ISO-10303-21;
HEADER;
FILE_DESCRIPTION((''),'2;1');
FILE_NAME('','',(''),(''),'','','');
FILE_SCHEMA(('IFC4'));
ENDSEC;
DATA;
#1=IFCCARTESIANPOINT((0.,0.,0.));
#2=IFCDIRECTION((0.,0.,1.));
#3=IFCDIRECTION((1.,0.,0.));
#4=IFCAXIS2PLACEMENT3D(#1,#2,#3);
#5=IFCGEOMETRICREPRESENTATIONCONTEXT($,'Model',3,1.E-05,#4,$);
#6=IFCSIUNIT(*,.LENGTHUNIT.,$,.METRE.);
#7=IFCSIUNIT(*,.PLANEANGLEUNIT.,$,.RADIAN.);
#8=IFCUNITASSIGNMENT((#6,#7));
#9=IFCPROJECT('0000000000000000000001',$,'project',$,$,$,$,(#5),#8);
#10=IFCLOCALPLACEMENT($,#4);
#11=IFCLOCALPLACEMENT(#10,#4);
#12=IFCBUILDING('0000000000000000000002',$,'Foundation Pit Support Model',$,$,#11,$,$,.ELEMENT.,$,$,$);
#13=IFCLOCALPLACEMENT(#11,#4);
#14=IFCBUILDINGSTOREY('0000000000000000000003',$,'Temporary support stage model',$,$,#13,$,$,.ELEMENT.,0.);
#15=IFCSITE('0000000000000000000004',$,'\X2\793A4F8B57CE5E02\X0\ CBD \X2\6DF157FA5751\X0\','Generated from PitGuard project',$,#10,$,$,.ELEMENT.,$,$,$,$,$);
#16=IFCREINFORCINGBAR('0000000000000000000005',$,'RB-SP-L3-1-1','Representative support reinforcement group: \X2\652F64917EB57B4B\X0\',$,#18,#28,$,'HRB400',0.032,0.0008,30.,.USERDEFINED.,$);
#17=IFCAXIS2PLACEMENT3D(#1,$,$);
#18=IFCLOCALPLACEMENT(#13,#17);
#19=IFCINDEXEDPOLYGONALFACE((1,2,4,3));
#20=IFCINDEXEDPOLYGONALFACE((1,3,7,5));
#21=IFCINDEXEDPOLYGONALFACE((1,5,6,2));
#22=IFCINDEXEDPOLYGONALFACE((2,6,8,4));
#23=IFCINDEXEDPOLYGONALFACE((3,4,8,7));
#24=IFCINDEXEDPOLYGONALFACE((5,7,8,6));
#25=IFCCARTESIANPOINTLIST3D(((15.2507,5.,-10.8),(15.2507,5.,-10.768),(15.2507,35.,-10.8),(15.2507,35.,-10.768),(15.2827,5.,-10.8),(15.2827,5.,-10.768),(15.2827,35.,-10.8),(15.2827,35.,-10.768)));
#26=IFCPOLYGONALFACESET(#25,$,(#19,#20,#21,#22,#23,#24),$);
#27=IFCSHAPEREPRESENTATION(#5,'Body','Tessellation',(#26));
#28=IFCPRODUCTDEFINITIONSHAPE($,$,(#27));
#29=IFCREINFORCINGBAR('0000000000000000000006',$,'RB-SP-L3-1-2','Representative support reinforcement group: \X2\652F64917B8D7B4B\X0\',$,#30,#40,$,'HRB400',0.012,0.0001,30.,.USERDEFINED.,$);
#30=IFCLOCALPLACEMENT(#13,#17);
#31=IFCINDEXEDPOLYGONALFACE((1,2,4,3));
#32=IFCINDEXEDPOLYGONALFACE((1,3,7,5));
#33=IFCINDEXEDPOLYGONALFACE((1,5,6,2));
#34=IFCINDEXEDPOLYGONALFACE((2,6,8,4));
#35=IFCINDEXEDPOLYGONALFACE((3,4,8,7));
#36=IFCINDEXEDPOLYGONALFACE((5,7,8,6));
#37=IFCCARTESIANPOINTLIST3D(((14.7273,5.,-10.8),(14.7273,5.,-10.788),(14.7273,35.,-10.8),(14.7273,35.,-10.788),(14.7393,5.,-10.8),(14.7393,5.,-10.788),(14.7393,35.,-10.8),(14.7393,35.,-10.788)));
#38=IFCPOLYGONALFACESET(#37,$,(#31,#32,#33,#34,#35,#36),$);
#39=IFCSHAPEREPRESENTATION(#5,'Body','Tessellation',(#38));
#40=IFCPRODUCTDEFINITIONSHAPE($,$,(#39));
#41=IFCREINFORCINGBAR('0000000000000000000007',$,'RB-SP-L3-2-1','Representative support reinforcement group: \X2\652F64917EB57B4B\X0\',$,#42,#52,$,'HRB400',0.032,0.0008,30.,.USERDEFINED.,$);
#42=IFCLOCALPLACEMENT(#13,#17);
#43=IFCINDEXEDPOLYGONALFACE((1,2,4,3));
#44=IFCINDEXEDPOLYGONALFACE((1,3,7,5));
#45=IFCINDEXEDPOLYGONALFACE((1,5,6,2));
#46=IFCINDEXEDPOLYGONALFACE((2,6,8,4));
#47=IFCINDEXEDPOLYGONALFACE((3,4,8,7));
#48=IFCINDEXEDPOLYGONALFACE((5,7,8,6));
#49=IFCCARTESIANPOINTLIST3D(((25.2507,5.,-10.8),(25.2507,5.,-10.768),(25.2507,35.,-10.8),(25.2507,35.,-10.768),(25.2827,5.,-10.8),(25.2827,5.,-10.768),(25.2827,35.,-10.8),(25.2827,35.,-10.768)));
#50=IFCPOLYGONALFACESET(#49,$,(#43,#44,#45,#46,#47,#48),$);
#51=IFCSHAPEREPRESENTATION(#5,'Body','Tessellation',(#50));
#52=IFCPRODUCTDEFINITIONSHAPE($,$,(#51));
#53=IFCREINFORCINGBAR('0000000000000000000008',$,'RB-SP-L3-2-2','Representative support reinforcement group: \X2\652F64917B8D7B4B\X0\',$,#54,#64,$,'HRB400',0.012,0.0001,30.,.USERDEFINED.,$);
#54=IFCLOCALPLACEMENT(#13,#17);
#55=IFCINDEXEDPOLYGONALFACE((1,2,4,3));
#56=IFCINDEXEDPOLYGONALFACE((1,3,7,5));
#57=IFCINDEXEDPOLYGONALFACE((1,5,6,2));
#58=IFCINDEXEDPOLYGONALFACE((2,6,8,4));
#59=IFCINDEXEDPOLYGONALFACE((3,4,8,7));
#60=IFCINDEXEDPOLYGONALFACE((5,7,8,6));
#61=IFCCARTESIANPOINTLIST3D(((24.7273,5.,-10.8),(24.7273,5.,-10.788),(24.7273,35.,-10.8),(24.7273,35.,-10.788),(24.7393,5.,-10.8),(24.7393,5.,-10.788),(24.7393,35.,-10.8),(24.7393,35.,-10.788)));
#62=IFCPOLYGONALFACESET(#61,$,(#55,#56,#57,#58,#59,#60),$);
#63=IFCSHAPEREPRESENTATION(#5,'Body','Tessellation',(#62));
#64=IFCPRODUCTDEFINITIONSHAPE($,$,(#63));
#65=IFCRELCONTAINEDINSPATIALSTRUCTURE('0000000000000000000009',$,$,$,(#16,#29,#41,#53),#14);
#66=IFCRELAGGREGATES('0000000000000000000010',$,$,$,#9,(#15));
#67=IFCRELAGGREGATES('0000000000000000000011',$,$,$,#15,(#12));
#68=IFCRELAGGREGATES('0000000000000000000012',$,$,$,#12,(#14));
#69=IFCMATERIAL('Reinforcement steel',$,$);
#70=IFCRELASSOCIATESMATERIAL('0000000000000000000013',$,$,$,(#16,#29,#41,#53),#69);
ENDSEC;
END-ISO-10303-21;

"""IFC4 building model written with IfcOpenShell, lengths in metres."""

from ifc_helpers import new_model, si_unit, frame, origin_with_axes, origin_2d, place, context, project, spatial, rectangle, extrude, material, element, save


model = new_model("IFC4")

# Units and contexts
model_context = context("Model", 3, precision=1e-05, world=origin_with_axes())
ifc_project = project(units=[si_unit("LENGTHUNIT", "METRE"), si_unit("PLANEANGLEUNIT", "RADIAN")], contexts=[model_context])

# Site, building, storey
site_placement = place(None, origin_with_axes())
site = spatial("IfcSite", under=ifc_project, at=site_placement, Name="示例城市 CBD 深基坑", Description="Generated from PitGuard project", CompositionType="ELEMENT")
building_placement = place(site_placement, origin_with_axes())
building = spatial("IfcBuilding", under=site, at=building_placement, Name="Foundation Pit Support Model", CompositionType="ELEMENT")
storey_placement = place(building_placement, origin_with_axes())
storey = spatial("IfcBuildingStorey", under=building, at=storey_placement, Name="Temporary support stage model", CompositionType="ELEMENT", Elevation=0.0)

# Reinforcing bars
ifc_material_1 = material(Name="Reinforcement steel")
reinforcing_bar_1_placement = place(storey_placement, frame((15.2667, 20.0, -10.8), z_axis=(0.0, 0.0, 1.0), x_axis=(0.0, 1.0, 0.0)))
element("IfcReinforcingBar", 1, at=reinforcing_bar_1_placement, inside=storey, material=ifc_material_1, Name="RB-SP-L3-1-1", Description="Representative support reinforcement group: 支撑纵筋", SteelGrade="HRB400", BarLength=30.0, CrossSectionArea=0.0008, NominalDiameter=0.032, PredefinedType="USERDEFINED", context=model_context, shape_type="SweptSolid", body=[
    extrude(rectangle(XDim=30.0, YDim=0.032, at=origin_2d()), origin_with_axes(), (0.0, 0.0, 1.0), 0.032),
])
reinforcing_bar_2_placement = place(storey_placement, frame((14.7333, 20.0, -10.8), z_axis=(0.0, 0.0, 1.0), x_axis=(0.0, 1.0, 0.0)))
element("IfcReinforcingBar", 2, at=reinforcing_bar_2_placement, inside=storey, material=ifc_material_1, Name="RB-SP-L3-1-2", Description="Representative support reinforcement group: 支撑箍筋", SteelGrade="HRB400", BarLength=30.0, CrossSectionArea=0.0001, NominalDiameter=0.012, PredefinedType="USERDEFINED", context=model_context, shape_type="SweptSolid", body=[
    extrude(rectangle(XDim=30.0, YDim=0.012, at=origin_2d()), origin_with_axes(), (0.0, 0.0, 1.0), 0.012),
])
reinforcing_bar_3_placement = place(storey_placement, frame((25.2667, 20.0, -10.8), z_axis=(0.0, 0.0, 1.0), x_axis=(0.0, 1.0, 0.0)))
element("IfcReinforcingBar", 3, at=reinforcing_bar_3_placement, inside=storey, material=ifc_material_1, Name="RB-SP-L3-2-1", Description="Representative support reinforcement group: 支撑纵筋", SteelGrade="HRB400", BarLength=30.0, CrossSectionArea=0.0008, NominalDiameter=0.032, PredefinedType="USERDEFINED", context=model_context, shape_type="SweptSolid", body=[
    extrude(rectangle(XDim=30.0, YDim=0.032, at=origin_2d()), origin_with_axes(), (0.0, 0.0, 1.0), 0.032),
])
reinforcing_bar_4_placement = place(storey_placement, frame((24.7333, 20.0, -10.8), z_axis=(0.0, 0.0, 1.0), x_axis=(0.0, 1.0, 0.0)))
element("IfcReinforcingBar", 4, at=reinforcing_bar_4_placement, inside=storey, material=ifc_material_1, Name="RB-SP-L3-2-2", Description="Representative support reinforcement group: 支撑箍筋", SteelGrade="HRB400", BarLength=30.0, CrossSectionArea=0.0001, NominalDiameter=0.012, PredefinedType="USERDEFINED", context=model_context, shape_type="SweptSolid", body=[
    extrude(rectangle(XDim=30.0, YDim=0.012, at=origin_2d()), origin_with_axes(), (0.0, 0.0, 1.0), 0.012),
])

save(model, "model.ifc")
